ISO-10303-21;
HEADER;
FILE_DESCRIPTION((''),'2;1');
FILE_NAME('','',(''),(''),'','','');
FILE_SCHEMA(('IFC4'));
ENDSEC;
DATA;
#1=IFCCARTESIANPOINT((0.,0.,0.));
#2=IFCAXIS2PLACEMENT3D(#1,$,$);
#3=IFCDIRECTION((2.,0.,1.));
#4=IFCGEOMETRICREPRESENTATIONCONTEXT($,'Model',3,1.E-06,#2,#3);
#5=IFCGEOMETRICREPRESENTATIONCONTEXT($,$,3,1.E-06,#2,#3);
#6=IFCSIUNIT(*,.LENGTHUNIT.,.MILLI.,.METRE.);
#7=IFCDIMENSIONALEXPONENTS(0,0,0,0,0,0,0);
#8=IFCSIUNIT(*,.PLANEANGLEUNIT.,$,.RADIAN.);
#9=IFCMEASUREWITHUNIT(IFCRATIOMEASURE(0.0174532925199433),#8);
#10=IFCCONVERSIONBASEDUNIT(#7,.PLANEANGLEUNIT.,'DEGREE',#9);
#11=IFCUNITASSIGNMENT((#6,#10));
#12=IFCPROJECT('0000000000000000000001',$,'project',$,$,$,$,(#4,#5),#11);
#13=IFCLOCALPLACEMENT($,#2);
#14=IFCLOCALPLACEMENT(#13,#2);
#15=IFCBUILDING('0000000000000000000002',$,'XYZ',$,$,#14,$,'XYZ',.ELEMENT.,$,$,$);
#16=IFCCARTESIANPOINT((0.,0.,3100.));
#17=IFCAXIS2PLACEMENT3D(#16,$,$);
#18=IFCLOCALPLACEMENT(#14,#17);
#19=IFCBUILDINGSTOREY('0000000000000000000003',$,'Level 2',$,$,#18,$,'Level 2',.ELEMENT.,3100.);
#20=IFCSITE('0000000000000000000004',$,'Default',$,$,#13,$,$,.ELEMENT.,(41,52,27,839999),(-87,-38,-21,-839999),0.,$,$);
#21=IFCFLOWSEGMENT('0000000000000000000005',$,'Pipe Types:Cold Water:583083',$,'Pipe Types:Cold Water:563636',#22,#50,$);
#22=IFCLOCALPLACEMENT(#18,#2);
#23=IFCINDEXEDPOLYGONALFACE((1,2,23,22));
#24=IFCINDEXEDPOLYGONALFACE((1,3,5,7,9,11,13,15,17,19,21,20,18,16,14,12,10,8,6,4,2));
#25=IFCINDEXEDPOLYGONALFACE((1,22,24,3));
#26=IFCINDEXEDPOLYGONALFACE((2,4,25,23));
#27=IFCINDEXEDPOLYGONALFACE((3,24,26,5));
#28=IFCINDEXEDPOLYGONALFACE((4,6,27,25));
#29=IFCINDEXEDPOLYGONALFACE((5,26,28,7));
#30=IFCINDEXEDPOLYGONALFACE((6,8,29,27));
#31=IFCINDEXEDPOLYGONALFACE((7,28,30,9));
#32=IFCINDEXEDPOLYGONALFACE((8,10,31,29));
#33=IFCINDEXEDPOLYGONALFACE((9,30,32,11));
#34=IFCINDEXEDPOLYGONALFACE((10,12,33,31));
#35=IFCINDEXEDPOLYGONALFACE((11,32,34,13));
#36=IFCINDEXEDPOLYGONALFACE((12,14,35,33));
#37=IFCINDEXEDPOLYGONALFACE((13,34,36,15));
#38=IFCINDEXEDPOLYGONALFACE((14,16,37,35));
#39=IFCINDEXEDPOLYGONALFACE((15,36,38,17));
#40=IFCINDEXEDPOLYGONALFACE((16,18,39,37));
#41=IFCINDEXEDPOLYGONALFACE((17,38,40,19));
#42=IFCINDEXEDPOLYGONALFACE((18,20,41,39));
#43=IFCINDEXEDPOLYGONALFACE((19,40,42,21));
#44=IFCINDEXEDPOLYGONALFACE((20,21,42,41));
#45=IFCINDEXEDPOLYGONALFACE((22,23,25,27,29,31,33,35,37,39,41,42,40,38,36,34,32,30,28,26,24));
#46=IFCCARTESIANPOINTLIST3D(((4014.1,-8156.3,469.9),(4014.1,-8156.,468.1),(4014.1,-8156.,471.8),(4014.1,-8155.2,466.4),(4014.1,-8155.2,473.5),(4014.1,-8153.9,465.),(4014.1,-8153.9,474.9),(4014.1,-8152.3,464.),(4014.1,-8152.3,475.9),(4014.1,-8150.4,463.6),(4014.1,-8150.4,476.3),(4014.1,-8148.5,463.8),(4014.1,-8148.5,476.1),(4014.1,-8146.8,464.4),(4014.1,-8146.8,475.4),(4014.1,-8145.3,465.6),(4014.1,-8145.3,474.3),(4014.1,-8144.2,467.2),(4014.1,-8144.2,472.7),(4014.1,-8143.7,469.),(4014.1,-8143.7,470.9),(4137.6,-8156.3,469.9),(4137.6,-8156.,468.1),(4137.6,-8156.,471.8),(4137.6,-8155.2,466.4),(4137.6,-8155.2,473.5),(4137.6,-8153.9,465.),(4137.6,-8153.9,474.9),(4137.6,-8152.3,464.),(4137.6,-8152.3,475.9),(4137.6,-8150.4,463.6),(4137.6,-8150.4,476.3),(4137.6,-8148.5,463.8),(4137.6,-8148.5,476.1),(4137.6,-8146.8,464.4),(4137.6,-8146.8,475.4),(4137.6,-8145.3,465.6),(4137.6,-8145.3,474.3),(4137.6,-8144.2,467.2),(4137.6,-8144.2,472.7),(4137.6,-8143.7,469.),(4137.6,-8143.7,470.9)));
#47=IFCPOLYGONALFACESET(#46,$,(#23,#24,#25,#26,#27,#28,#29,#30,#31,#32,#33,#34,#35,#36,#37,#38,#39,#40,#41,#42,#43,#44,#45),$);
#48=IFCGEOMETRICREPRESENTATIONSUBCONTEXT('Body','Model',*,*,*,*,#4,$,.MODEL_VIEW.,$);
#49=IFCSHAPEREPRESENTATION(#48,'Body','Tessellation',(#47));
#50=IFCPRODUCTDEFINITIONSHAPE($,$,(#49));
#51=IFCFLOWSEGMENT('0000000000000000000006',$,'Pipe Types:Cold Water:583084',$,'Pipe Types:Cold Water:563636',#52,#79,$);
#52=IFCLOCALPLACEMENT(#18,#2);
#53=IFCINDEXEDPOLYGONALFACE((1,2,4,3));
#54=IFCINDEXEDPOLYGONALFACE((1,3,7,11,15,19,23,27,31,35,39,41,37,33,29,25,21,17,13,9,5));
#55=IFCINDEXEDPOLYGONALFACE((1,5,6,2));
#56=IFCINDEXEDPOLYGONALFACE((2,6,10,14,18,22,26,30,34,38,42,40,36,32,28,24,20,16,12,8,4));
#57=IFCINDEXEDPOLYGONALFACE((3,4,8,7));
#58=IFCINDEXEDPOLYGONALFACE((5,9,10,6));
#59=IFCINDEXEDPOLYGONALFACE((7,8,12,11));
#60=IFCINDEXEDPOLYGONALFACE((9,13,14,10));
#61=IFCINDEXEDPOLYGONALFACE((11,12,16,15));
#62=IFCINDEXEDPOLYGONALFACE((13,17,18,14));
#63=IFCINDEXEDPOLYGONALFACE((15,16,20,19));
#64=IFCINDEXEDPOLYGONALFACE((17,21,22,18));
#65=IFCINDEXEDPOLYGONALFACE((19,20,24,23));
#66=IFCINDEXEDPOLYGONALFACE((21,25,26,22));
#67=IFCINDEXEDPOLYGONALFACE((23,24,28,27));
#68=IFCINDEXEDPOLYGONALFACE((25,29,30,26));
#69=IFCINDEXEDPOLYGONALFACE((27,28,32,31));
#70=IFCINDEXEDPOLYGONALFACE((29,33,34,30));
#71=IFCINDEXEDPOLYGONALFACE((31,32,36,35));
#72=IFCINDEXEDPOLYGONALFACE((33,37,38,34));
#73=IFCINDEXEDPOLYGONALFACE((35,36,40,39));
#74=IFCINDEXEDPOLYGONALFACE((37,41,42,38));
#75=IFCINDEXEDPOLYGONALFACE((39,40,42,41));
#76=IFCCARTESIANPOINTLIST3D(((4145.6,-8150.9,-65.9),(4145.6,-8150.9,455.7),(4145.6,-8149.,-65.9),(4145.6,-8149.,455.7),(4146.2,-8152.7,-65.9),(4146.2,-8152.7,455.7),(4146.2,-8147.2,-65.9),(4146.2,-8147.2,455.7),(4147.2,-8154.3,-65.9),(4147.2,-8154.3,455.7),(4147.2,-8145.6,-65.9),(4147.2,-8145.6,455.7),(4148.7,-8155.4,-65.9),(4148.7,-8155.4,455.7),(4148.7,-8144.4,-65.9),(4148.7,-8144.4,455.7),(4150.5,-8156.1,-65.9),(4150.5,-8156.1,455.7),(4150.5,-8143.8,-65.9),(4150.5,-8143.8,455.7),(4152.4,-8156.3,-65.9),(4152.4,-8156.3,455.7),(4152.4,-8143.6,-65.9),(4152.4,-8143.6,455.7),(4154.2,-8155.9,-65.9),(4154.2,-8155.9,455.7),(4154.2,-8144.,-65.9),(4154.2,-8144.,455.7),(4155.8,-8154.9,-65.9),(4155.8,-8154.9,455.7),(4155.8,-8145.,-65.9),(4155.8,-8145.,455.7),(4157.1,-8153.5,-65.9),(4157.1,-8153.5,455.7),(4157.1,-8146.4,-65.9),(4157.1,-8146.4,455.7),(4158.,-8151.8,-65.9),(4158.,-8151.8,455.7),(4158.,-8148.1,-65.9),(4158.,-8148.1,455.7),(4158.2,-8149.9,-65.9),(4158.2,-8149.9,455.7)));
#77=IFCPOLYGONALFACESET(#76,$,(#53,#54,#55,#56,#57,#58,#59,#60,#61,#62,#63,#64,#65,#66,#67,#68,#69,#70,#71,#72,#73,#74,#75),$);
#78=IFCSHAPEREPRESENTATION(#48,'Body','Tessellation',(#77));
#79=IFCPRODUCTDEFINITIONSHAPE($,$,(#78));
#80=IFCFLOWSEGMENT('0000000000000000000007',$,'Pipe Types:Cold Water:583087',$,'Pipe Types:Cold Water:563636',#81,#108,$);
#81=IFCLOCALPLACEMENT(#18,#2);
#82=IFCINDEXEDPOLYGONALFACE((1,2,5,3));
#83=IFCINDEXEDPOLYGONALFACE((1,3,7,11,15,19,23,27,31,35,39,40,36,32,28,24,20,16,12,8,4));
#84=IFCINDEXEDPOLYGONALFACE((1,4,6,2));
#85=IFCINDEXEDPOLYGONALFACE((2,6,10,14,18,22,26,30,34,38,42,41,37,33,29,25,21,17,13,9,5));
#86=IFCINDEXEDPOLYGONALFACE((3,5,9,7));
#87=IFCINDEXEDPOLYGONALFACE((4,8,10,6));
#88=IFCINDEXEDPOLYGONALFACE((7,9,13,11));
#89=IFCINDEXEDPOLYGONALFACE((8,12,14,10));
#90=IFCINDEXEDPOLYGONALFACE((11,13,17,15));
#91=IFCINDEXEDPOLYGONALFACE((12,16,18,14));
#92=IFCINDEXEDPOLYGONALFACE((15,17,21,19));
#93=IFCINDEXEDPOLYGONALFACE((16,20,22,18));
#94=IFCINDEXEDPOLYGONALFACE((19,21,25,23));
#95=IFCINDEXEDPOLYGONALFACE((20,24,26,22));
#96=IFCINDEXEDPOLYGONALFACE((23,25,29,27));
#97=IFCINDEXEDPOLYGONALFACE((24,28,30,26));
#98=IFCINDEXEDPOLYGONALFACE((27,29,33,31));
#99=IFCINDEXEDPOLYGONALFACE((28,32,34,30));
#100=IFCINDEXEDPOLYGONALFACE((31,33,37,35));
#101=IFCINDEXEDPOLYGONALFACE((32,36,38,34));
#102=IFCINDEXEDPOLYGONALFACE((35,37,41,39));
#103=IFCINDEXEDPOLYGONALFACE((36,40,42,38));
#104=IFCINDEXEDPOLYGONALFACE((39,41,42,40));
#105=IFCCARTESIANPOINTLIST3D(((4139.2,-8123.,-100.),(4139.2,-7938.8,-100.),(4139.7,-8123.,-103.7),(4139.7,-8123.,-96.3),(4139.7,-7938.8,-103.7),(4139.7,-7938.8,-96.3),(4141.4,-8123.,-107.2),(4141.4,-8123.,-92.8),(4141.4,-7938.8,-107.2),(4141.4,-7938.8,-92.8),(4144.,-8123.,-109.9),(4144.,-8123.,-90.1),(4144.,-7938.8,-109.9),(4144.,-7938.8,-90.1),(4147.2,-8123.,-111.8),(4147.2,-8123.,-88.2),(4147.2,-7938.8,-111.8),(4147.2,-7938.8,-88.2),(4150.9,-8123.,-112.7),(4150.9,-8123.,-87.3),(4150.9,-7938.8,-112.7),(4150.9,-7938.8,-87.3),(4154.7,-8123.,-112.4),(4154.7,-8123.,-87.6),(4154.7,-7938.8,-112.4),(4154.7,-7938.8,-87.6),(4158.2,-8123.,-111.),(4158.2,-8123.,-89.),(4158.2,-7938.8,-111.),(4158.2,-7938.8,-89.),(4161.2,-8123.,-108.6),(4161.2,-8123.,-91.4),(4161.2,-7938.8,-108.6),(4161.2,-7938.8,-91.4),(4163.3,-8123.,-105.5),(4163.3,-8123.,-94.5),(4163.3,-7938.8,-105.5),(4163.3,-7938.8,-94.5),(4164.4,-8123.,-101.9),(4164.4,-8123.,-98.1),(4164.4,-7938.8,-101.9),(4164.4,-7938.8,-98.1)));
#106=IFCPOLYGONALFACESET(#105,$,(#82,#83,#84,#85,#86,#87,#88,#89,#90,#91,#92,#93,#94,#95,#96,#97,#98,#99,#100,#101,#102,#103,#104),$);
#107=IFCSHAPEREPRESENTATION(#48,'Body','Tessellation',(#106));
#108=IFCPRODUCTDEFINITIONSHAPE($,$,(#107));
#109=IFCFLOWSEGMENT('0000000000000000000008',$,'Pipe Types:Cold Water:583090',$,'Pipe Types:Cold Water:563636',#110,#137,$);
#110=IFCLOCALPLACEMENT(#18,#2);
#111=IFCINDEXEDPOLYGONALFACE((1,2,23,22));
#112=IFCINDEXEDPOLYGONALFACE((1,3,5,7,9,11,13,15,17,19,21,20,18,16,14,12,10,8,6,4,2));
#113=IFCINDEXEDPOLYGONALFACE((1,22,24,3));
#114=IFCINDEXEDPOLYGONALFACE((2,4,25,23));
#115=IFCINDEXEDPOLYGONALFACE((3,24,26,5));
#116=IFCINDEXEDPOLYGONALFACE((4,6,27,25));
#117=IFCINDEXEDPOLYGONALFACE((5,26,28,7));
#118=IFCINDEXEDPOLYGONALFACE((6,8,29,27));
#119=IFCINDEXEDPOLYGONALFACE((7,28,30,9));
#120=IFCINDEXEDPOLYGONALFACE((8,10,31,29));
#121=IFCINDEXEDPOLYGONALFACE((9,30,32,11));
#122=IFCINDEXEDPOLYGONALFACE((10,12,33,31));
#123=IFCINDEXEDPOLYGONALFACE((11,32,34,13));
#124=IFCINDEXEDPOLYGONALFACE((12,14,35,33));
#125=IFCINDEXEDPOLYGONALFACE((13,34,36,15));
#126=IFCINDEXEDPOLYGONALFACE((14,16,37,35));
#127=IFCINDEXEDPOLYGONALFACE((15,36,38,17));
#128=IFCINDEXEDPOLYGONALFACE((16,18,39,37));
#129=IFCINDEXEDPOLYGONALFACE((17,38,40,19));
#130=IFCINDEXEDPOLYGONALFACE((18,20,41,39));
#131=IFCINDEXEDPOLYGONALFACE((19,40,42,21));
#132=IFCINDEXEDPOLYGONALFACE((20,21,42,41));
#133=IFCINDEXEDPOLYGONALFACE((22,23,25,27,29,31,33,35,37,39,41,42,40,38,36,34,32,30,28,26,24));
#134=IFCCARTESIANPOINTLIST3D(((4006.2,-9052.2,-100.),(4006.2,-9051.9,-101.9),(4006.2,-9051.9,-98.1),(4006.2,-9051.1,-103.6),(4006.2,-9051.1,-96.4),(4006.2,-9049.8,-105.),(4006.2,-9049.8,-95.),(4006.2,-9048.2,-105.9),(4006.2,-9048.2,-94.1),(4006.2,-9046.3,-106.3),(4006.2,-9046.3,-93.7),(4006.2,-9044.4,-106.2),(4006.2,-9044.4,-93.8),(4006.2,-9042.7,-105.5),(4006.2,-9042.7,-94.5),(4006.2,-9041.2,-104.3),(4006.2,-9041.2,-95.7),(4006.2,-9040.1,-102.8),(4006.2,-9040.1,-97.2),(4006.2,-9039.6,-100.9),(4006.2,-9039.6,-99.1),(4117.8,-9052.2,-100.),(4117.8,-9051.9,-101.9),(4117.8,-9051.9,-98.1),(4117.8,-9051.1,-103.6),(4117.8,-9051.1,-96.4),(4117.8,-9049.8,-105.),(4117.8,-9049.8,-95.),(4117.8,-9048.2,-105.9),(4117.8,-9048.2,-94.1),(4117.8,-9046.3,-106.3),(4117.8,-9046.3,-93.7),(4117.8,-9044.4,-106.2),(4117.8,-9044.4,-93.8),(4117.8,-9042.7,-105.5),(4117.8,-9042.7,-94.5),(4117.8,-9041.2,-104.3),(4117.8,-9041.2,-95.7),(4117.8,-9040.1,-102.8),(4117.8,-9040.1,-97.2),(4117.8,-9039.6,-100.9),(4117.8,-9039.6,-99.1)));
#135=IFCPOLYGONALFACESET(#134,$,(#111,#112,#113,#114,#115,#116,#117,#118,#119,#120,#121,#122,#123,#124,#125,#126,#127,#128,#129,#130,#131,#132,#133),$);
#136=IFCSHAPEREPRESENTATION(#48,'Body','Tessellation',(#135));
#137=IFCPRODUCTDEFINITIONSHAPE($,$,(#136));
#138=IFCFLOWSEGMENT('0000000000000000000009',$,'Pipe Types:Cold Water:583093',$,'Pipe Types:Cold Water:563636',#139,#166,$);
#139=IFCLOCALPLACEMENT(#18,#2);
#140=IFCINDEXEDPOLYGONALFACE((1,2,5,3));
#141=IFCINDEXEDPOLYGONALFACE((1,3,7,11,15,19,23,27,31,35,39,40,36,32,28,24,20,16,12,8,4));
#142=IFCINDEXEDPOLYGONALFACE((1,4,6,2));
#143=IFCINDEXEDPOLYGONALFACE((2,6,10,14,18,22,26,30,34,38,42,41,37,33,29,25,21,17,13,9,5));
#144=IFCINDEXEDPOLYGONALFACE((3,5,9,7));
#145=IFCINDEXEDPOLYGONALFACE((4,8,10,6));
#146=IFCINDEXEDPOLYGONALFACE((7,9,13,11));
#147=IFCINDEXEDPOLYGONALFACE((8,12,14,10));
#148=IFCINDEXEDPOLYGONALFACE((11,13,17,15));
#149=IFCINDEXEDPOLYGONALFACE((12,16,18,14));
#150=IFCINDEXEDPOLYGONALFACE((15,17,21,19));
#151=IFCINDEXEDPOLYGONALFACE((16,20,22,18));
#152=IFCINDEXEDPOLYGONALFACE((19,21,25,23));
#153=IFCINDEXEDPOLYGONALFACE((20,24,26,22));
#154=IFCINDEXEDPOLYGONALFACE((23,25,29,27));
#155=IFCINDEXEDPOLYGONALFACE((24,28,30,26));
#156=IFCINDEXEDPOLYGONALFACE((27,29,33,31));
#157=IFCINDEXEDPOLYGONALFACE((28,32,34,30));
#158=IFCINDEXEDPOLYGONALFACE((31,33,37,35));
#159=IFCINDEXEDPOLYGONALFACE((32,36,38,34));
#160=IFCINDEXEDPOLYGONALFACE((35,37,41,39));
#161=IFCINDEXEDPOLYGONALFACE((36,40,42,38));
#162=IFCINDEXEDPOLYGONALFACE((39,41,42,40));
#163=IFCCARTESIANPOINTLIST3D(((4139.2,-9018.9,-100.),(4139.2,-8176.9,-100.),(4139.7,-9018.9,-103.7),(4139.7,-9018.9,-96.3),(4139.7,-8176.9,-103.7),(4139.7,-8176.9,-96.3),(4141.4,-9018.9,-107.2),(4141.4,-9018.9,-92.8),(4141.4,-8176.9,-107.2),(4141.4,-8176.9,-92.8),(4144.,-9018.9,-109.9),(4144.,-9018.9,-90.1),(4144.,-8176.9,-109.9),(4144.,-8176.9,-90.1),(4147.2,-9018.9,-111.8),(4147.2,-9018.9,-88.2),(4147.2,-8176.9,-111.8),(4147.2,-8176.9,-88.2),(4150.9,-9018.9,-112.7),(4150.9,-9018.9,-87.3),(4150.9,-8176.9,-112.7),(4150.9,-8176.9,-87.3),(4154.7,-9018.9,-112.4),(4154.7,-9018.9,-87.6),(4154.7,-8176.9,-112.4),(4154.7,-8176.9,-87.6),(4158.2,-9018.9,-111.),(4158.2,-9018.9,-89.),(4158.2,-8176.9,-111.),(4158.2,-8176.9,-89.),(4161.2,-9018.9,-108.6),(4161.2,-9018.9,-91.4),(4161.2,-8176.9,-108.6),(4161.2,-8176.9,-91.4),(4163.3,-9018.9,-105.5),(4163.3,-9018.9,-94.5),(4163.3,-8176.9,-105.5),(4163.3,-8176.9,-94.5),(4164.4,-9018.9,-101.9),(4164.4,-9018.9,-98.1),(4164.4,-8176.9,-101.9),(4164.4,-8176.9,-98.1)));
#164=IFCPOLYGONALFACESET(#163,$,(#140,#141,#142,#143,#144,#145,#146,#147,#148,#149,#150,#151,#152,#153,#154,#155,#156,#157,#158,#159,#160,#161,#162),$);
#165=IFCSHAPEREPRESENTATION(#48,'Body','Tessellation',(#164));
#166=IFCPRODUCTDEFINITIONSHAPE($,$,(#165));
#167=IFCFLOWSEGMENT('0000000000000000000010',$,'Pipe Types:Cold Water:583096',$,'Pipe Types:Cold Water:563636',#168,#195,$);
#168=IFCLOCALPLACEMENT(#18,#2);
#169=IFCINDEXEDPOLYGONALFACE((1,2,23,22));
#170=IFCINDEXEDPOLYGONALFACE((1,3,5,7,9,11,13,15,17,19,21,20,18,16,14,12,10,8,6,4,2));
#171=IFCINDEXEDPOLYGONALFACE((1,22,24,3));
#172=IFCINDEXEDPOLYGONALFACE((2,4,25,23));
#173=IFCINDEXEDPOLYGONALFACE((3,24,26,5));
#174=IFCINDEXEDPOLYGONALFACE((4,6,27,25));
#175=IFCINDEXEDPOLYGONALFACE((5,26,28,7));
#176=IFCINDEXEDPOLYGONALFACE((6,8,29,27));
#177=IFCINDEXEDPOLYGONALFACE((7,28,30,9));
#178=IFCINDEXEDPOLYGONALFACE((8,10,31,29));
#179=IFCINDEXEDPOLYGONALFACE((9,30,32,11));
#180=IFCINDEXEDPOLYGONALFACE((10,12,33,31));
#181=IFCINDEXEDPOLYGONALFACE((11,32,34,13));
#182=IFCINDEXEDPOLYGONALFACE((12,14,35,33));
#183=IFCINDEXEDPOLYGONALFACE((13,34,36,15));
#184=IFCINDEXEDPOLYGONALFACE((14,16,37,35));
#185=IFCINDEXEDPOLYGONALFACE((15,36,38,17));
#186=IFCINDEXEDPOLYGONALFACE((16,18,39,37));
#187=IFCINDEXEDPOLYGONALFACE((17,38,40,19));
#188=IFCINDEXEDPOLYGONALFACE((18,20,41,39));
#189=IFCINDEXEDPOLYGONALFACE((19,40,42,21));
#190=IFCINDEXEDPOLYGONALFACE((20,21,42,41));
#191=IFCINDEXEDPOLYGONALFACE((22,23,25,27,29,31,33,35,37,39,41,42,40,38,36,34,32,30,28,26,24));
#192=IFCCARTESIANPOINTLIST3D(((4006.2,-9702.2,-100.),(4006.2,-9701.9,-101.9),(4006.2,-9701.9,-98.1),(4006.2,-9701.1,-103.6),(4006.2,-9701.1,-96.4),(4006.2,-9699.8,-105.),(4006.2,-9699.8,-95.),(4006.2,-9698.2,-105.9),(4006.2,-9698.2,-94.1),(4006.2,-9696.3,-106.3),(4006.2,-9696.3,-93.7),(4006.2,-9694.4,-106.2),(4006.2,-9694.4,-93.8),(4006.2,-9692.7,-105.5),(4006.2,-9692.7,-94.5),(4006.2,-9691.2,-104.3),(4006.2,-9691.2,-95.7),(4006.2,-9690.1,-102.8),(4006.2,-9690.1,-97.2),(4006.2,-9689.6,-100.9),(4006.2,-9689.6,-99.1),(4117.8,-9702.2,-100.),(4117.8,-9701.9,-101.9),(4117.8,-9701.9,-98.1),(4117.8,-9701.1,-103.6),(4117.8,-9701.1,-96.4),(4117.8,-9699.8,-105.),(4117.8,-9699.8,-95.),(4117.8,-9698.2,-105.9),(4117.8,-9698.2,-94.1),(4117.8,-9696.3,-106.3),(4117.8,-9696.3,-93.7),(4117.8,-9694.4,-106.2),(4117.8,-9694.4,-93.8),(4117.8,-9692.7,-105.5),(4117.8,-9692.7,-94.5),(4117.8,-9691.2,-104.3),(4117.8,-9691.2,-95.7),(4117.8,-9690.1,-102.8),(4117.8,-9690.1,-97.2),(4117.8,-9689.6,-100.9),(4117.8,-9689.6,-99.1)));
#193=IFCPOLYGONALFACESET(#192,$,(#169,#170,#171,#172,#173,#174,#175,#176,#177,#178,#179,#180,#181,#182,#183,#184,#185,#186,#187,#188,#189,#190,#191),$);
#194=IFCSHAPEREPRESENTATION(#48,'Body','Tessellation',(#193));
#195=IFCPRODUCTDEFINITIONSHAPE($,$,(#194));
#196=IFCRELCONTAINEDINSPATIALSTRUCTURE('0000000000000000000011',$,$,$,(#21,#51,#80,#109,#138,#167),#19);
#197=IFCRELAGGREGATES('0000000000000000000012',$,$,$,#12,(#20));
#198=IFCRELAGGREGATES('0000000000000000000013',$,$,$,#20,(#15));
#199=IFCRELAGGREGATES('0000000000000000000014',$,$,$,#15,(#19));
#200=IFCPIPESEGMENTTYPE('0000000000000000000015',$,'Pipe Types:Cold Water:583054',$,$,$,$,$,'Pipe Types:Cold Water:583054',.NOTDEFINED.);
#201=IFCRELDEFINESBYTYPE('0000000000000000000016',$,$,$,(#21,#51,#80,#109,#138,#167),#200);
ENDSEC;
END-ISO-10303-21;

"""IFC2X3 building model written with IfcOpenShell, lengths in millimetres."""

from ifc_helpers import new_model, entity, si_unit, converted_unit, direction, frame, frame_2d, origin, origin_2d_with_axis, place, context, subcontext, project, spatial, circle, extrude, type_object, element, save


model = new_model("IFC2X3")

# Units and contexts
model_context = context("Model", 3, precision=1e-06, world=origin(), true_north=direction((2.0, 0.0, 1.0)))
context_of_model = context(None, 3, precision=1e-06, world=origin(), true_north=direction((2.0, 0.0, 1.0)))
body_context = subcontext(model_context, "Body", "Model", "MODEL_VIEW")
ifc_project = project(units=[si_unit("LENGTHUNIT", "METRE", prefix="MILLI"), converted_unit("PLANEANGLEUNIT", "DEGREE", entity("IfcRatioMeasure", 0.0174532925199433), si_unit("PLANEANGLEUNIT", "RADIAN"), dimensions=[0, 0, 0, 0, 0, 0, 0])], contexts=[model_context, context_of_model])

# Site, building, storey
site_placement = place(None, origin())
site = spatial("IfcSite", under=ifc_project, at=site_placement, Name="Default", CompositionType="ELEMENT", RefLatitude=(41, 52, 27, 839999), RefLongitude=(-87, -38, -21, -839999), RefElevation=0.0)
building_placement = place(site_placement, origin())
building = spatial("IfcBuilding", under=site, at=building_placement, Name="XYZ", LongName="XYZ", CompositionType="ELEMENT")
storey_placement = place(building_placement, frame((0.0, 0.0, 3100.0)))
storey = spatial("IfcBuildingStorey", under=building, at=storey_placement, Name="Level 2", LongName="Level 2", CompositionType="ELEMENT", Elevation=3100.0)

# Flow segments
pipe_segment_type_1 = type_object("IfcPipeSegmentType", Name="Pipe Types:Cold Water:583054", ElementType="Pipe Types:Cold Water:583054", PredefinedType="NOTDEFINED")
flow_segment_1_placement = place(storey_placement, origin())
element("IfcFlowSegment", 1, at=flow_segment_1_placement, inside=storey, type_object=pipe_segment_type_1, Name="Pipe Types:Cold Water:583083", ObjectType="Pipe Types:Cold Water:563636", context=body_context, shape_type="SweptSolid", body=[
    extrude(circle(Radius=6.3, at=frame_2d((0.0, 0.0), x_axis=(1.0, 0.0))), frame((4014.1, -8149.9, 469.9), z_axis=(1.0, 0.0, 0.0), x_axis=(0.0, -1.0, 0.0)), (0.0, 0.0, 1.0), 123.5),
])
flow_segment_2_placement = place(storey_placement, origin())
element("IfcFlowSegment", 2, at=flow_segment_2_placement, inside=storey, type_object=pipe_segment_type_1, Name="Pipe Types:Cold Water:583084", ObjectType="Pipe Types:Cold Water:563636", context=body_context, shape_type="SweptSolid", body=[
    extrude(circle(Radius=6.3, at=origin_2d_with_axis()), frame((4151.9, -8149.9, -65.9)), (0.0, 0.0, 1.0), 521.5),
])
flow_segment_3_placement = place(storey_placement, origin())
element("IfcFlowSegment", 3, at=flow_segment_3_placement, inside=storey, type_object=pipe_segment_type_1, Name="Pipe Types:Cold Water:583087", ObjectType="Pipe Types:Cold Water:563636", context=body_context, shape_type="SweptSolid", body=[
    extrude(circle(Radius=12.7, at=frame_2d((0.0, 0.0), x_axis=(1.0, 0.0))), frame((4151.9, -8123.0, -100.0), z_axis=(0.0, 1.0, 0.0), x_axis=(-1.0, 0.0, 0.0)), (0.0, 0.0, 1.0), 184.2),
])
flow_segment_4_placement = place(storey_placement, origin())
element("IfcFlowSegment", 4, at=flow_segment_4_placement, inside=storey, type_object=pipe_segment_type_1, Name="Pipe Types:Cold Water:583090", ObjectType="Pipe Types:Cold Water:563636", context=body_context, shape_type="SweptSolid", body=[
    extrude(circle(Radius=6.3, at=origin_2d_with_axis()), frame((4006.2, -9045.9, -100.0), z_axis=(1.0, 0.0, 0.0), x_axis=(0.0, -1.0, 0.0)), (0.0, 0.0, 1.0), 111.6),
])
flow_segment_5_placement = place(storey_placement, origin())
element("IfcFlowSegment", 5, at=flow_segment_5_placement, inside=storey, type_object=pipe_segment_type_1, Name="Pipe Types:Cold Water:583093", ObjectType="Pipe Types:Cold Water:563636", context=body_context, shape_type="SweptSolid", body=[
    extrude(circle(Radius=12.7, at=frame_2d((0.0, 0.0), x_axis=(1.0, 0.0))), frame((4151.9, -9018.9, -100.0), z_axis=(0.0, 1.0, 0.0), x_axis=(-1.0, 0.0, 0.0)), (0.0, 0.0, 1.0), 841.9),
])
flow_segment_6_placement = place(storey_placement, origin())
element("IfcFlowSegment", 6, at=flow_segment_6_placement, inside=storey, type_object=pipe_segment_type_1, Name="Pipe Types:Cold Water:583096", ObjectType="Pipe Types:Cold Water:563636", context=body_context, shape_type="SweptSolid", body=[
    extrude(circle(Radius=6.3, at=origin_2d_with_axis()), frame((4006.2, -9695.9, -100.0), z_axis=(1.0, 0.0, 0.0), x_axis=(0.0, -1.0, 0.0)), (0.0, 0.0, 1.0), 111.6),
])

save(model, "model.ifc")
